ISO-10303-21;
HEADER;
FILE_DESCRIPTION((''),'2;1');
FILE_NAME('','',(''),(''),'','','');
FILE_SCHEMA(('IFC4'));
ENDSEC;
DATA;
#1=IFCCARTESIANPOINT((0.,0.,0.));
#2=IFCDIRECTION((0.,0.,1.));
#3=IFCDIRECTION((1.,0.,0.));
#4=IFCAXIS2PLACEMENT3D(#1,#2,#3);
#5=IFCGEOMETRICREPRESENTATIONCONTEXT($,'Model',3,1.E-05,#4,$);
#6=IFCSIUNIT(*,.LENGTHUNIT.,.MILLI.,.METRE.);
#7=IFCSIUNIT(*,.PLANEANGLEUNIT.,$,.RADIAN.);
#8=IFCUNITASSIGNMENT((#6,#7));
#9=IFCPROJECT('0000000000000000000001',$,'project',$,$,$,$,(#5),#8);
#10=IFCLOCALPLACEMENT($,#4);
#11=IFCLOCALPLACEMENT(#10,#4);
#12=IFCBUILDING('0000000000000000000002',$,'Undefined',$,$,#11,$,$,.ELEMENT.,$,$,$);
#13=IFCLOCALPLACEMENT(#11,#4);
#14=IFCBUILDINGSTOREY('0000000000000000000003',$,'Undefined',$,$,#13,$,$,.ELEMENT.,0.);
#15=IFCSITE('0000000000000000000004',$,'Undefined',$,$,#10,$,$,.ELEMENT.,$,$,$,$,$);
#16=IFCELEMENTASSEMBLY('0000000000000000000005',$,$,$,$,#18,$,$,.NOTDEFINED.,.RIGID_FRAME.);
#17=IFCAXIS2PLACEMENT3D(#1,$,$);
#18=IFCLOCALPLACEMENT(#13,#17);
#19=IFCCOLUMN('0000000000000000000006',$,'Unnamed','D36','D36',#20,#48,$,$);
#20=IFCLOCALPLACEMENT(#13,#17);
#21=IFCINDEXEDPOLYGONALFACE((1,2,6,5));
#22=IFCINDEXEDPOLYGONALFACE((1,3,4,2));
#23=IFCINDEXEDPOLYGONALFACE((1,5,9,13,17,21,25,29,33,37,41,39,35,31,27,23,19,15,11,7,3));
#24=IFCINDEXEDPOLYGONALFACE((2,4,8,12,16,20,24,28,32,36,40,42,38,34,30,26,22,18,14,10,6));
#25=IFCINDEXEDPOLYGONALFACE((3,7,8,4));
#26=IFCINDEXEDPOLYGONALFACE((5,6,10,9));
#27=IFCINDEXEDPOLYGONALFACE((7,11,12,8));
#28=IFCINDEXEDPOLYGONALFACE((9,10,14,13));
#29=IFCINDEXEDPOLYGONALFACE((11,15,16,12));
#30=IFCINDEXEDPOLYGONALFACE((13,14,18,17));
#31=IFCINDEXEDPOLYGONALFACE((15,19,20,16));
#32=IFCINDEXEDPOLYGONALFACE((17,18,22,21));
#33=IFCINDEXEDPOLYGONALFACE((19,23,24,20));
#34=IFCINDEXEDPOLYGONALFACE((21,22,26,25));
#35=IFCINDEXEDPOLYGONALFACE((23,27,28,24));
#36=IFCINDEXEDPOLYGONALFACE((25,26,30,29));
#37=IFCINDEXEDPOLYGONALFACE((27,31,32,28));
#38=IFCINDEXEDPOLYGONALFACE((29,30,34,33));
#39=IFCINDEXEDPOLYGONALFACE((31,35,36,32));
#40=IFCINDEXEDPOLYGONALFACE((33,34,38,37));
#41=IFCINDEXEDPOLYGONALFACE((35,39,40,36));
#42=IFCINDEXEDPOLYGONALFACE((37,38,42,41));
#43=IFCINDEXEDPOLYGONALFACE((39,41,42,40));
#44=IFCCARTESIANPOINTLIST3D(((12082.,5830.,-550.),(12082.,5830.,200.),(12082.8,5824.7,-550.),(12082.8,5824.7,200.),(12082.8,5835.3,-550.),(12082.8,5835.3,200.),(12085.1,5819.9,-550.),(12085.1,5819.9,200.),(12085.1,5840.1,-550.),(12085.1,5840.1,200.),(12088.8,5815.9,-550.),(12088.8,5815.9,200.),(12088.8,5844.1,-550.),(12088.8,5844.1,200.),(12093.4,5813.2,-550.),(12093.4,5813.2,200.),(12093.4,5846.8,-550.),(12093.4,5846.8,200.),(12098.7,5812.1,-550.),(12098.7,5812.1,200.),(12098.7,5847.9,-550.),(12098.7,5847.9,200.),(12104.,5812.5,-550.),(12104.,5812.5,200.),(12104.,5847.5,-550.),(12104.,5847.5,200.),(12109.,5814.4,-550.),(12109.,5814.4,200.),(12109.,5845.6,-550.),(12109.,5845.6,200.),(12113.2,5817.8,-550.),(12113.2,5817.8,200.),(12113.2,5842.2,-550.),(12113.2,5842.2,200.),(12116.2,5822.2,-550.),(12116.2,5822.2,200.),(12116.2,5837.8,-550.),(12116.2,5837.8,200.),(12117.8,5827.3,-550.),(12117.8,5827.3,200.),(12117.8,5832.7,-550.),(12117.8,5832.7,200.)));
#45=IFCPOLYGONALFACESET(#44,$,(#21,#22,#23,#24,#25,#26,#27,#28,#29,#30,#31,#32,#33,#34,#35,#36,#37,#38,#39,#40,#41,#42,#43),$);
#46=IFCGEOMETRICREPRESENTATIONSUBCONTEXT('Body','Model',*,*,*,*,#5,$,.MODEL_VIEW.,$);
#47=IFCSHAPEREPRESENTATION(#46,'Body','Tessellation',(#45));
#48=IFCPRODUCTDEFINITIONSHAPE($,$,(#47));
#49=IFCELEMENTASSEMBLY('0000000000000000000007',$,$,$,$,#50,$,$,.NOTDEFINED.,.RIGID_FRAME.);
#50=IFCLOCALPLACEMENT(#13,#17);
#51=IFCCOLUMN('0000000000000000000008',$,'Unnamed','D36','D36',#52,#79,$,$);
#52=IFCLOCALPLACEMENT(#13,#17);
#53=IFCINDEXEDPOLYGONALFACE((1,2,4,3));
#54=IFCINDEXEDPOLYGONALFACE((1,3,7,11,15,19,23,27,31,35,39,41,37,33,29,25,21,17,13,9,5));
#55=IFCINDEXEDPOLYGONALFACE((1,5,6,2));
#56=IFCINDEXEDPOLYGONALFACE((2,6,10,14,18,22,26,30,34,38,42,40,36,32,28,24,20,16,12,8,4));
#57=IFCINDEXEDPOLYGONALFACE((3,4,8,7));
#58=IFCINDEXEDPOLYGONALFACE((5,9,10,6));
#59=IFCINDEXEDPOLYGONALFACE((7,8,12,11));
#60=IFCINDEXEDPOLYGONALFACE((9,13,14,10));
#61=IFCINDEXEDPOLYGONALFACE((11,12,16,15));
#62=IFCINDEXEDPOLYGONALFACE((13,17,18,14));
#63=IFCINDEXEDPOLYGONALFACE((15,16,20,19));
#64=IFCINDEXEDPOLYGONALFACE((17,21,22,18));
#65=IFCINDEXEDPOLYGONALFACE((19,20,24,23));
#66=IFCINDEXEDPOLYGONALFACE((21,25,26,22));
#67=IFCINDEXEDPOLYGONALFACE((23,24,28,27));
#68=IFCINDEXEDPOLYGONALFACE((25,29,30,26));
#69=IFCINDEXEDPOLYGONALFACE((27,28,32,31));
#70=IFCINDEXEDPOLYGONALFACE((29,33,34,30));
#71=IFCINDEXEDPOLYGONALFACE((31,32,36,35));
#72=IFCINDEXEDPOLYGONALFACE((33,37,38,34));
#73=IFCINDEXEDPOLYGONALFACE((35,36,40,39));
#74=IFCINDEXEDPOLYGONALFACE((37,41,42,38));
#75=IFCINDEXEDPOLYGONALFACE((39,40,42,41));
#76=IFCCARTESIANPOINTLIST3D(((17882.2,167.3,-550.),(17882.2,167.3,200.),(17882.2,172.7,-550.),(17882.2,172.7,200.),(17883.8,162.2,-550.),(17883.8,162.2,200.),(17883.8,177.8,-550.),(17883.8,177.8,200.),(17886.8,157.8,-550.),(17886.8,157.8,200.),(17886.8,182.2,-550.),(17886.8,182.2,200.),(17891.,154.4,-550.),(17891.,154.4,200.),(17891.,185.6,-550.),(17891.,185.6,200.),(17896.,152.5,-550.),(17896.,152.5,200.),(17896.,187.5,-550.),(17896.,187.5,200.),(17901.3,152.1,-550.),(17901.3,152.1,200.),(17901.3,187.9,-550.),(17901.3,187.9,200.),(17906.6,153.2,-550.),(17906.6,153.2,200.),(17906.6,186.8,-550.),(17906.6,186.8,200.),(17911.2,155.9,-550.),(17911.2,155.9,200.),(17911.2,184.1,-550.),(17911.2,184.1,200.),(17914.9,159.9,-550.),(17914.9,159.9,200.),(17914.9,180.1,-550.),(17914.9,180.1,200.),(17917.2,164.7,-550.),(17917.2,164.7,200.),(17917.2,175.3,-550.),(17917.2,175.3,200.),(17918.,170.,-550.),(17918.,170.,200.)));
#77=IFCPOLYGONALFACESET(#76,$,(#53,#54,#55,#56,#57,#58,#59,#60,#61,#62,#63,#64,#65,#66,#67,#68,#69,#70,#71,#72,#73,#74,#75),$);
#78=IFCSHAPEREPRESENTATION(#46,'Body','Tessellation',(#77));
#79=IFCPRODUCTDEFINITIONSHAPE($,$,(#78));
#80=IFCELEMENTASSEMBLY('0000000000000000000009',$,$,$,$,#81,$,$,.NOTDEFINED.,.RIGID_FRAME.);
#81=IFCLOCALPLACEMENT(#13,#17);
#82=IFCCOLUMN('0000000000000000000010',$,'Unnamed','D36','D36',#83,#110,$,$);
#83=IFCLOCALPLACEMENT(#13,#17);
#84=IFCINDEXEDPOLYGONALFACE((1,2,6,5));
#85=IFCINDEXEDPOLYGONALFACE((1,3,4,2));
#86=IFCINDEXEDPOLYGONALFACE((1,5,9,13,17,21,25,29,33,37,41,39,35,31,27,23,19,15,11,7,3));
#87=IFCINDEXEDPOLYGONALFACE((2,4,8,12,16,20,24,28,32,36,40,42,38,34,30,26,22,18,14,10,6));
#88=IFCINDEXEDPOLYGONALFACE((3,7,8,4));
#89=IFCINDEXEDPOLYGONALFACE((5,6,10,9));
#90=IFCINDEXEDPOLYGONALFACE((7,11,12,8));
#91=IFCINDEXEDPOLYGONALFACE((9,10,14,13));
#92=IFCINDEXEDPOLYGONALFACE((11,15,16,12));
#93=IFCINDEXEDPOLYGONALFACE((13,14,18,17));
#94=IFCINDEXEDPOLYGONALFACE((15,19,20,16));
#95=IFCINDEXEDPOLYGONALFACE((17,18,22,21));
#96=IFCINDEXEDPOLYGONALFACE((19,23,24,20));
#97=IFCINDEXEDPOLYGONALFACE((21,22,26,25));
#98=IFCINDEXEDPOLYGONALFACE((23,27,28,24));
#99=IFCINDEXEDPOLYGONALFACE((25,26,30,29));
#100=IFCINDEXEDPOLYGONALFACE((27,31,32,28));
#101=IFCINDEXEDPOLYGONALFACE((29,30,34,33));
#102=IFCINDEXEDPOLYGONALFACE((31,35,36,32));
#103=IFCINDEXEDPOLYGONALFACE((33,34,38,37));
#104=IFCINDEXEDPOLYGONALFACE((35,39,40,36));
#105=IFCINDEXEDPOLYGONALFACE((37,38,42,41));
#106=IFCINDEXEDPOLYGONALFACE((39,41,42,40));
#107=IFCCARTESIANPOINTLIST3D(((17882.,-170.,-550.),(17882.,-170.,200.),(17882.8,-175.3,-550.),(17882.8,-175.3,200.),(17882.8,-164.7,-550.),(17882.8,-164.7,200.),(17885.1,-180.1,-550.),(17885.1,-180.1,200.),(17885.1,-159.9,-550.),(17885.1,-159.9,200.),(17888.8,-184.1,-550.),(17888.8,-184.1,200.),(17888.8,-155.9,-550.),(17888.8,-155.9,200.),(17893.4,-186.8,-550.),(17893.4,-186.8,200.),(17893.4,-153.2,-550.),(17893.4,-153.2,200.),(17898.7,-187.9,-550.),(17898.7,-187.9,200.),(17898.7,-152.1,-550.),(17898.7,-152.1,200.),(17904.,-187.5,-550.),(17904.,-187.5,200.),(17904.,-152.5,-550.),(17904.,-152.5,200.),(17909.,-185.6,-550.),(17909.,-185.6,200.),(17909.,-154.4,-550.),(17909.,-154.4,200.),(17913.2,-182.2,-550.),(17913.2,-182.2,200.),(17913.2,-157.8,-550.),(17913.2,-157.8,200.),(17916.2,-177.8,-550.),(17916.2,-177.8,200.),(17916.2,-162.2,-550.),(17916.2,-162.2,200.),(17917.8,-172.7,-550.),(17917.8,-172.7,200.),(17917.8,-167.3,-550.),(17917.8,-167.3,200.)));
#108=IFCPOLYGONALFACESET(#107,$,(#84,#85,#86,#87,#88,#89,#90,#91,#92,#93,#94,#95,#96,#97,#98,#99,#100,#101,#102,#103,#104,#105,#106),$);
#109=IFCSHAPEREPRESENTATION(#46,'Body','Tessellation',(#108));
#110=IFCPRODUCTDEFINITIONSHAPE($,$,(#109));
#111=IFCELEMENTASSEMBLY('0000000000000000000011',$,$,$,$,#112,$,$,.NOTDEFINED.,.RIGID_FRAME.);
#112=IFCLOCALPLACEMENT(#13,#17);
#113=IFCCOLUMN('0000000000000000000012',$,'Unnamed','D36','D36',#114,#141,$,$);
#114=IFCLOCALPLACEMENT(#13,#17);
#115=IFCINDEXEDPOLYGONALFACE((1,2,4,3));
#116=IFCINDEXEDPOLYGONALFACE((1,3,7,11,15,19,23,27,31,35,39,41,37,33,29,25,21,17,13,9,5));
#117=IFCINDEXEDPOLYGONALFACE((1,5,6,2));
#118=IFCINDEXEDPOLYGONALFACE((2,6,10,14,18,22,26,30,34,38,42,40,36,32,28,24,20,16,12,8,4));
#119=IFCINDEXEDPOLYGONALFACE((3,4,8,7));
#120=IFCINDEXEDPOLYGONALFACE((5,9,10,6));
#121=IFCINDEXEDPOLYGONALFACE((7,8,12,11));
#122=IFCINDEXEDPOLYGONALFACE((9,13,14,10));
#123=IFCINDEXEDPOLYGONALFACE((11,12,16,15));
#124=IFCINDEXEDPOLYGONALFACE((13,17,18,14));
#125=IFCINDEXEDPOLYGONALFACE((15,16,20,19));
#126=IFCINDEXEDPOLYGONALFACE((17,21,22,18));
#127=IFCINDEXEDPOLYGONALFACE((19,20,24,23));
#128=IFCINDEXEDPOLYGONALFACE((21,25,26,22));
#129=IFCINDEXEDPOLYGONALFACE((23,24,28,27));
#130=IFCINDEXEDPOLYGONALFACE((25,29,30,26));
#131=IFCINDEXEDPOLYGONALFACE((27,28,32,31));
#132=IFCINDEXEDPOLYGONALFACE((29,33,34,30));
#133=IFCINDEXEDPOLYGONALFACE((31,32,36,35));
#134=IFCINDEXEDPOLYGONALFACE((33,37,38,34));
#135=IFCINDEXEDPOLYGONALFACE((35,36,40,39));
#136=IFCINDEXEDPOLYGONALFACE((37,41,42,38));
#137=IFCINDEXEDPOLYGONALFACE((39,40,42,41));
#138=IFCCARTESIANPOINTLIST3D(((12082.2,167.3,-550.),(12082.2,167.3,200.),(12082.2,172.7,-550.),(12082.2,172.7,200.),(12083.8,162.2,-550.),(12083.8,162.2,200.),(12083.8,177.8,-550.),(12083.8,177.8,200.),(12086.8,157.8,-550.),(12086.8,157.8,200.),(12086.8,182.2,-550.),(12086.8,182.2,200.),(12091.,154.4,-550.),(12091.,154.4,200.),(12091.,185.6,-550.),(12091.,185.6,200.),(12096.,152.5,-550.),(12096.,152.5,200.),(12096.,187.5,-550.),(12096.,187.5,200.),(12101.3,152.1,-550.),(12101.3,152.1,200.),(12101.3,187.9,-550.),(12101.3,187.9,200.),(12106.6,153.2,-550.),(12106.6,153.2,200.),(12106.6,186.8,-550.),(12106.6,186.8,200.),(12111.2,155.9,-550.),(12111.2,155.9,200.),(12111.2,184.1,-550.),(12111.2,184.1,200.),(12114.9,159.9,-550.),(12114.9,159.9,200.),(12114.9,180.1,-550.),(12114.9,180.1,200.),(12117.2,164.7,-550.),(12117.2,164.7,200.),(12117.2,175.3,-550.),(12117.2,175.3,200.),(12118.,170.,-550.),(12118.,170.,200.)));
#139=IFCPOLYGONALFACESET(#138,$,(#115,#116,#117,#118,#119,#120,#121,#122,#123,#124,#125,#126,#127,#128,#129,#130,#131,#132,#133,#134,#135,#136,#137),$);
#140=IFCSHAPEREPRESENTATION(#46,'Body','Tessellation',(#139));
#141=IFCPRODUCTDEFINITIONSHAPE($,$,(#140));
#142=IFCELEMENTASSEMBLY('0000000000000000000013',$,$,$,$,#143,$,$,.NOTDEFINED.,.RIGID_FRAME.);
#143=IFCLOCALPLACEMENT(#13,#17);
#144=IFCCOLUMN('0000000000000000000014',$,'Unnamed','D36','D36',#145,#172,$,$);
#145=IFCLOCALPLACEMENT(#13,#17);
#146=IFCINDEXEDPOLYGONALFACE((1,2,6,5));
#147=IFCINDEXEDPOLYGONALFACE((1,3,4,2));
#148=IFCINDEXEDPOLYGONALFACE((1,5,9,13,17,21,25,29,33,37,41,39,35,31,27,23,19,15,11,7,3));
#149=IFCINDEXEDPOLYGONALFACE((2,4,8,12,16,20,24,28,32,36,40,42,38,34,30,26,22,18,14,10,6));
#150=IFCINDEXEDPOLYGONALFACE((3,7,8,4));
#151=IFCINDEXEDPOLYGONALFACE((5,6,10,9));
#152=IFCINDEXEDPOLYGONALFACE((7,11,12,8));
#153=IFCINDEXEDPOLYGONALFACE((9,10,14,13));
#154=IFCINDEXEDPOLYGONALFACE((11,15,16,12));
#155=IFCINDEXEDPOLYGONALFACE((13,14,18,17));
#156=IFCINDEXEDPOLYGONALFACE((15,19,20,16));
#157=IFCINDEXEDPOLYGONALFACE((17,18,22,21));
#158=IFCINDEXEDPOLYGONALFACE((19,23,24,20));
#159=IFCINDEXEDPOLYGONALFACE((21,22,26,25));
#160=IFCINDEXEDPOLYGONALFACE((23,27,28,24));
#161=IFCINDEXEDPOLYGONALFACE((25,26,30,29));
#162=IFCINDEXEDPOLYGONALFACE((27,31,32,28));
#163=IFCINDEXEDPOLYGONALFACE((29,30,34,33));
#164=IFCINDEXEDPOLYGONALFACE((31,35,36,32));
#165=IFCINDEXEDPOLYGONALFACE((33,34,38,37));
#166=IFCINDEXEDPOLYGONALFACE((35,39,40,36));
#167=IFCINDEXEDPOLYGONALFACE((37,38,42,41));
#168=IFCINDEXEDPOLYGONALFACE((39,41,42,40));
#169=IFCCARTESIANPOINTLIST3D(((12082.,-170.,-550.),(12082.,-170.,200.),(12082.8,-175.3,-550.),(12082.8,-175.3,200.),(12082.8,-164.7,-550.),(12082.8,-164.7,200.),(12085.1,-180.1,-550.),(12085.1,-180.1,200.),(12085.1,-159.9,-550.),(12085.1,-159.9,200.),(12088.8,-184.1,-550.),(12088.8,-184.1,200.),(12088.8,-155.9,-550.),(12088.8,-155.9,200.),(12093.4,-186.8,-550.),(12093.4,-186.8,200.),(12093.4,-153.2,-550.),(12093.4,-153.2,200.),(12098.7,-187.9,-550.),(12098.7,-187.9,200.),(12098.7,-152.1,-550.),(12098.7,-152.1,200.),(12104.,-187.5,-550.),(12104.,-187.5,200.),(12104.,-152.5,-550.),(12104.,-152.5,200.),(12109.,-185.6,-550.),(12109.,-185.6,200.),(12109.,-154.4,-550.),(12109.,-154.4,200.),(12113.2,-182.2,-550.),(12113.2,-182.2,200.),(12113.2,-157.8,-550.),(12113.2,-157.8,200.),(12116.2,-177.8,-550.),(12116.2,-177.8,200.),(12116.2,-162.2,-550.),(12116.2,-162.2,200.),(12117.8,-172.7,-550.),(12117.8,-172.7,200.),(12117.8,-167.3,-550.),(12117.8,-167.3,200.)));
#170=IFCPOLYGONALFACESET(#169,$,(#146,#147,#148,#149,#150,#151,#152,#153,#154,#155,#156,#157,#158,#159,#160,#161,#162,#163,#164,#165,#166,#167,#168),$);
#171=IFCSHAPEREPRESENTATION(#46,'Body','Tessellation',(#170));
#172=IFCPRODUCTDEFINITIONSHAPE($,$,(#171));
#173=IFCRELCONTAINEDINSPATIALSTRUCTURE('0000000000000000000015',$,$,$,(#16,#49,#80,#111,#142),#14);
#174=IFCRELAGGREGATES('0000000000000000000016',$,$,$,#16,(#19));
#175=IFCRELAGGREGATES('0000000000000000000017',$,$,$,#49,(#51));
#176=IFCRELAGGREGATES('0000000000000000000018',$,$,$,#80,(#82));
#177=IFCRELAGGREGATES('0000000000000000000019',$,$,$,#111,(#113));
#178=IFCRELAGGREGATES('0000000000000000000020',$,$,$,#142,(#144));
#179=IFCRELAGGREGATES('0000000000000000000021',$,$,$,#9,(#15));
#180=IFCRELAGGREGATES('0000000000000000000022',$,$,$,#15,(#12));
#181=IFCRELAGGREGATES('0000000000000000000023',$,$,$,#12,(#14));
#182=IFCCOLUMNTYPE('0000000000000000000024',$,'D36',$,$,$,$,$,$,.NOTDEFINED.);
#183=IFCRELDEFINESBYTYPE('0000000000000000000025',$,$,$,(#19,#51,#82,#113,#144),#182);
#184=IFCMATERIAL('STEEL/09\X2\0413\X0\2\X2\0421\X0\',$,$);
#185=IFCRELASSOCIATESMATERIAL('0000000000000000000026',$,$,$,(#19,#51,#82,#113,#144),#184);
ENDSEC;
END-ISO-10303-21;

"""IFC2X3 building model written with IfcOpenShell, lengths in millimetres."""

from ifc_helpers import new_model, si_unit, frame, origin_with_axes, origin_2d_with_axis, place, context, subcontext, project, spatial, circle, extrude, material, type_object, element, aggregate, save


model = new_model("IFC2X3")

# Units and contexts
model_context = context("Model", 3, precision=1e-05, world=origin_with_axes())
body_context = subcontext(model_context, "Body", "Model", "MODEL_VIEW")
ifc_project = project(units=[si_unit("LENGTHUNIT", "METRE", prefix="MILLI"), si_unit("PLANEANGLEUNIT", "RADIAN")], contexts=[model_context])

# Site, building, storey
site_placement = place(None, origin_with_axes())
site = spatial("IfcSite", under=ifc_project, at=site_placement, Name="Undefined", CompositionType="ELEMENT")
building_placement = place(site_placement, origin_with_axes())
building = spatial("IfcBuilding", under=site, at=building_placement, Name="Undefined", CompositionType="ELEMENT")
storey_placement = place(building_placement, origin_with_axes())
storey = spatial("IfcBuildingStorey", under=building, at=storey_placement, Name="Undefined", CompositionType="ELEMENT", Elevation=0.0)

# Element assemblies, columns
ifc_material_1 = material(Name="STEEL/09Г2С")
column_type_1 = type_object("IfcColumnType", Name="D36", PredefinedType="NOTDEFINED")
assembly_1_placement = place(storey_placement, origin_with_axes())
assembly_1 = element("IfcElementAssembly", 1, at=assembly_1_placement, inside=storey, AssemblyPlace="NOTDEFINED", PredefinedType="RIGID_FRAME")
column_1_placement = place(assembly_1_placement, frame((12100.0, 5830.0, -550.0), z_axis=(0.0, 0.0, 1.0), x_axis=(0.0, 1.0, 0.0)))
column_1 = element("IfcColumn", 2, at=column_1_placement, type_object=column_type_1, material=ifc_material_1, Name="Unnamed", Description="D36", ObjectType="D36", context=body_context, shape_type="SweptSolid", body=[
    extrude(circle(Radius=18.0, at=origin_2d_with_axis()), frame((0.0, 0.0, 750.0), z_axis=(0.0, 0.0, -1.0), x_axis=(0.0, 1.0, 0.0)), (0.0, 0.0, 1.0), 750.0),
])
aggregate(assembly_1, [column_1])
assembly_2_placement = place(storey_placement, origin_with_axes())
assembly_2 = element("IfcElementAssembly", 3, at=assembly_2_placement, inside=storey, AssemblyPlace="NOTDEFINED", PredefinedType="RIGID_FRAME")
column_2_placement = place(assembly_2_placement, frame((17900.0, 170.0, -550.0), z_axis=(0.0, 0.0, 1.0), x_axis=(0.0, -1.0, 0.0)))
column_2 = element("IfcColumn", 4, at=column_2_placement, type_object=column_type_1, material=ifc_material_1, Name="Unnamed", Description="D36", ObjectType="D36", context=body_context, shape_type="SweptSolid", body=[
    extrude(circle(Radius=18.0, at=origin_2d_with_axis()), frame((0.0, 0.0, 750.0), z_axis=(0.0, 0.0, -1.0), x_axis=(0.0, 1.0, 0.0)), (0.0, 0.0, 1.0), 750.0),
])
aggregate(assembly_2, [column_2])
assembly_3_placement = place(storey_placement, origin_with_axes())
assembly_3 = element("IfcElementAssembly", 5, at=assembly_3_placement, inside=storey, AssemblyPlace="NOTDEFINED", PredefinedType="RIGID_FRAME")
column_3_placement = place(assembly_3_placement, frame((17900.0, -170.0, -550.0), z_axis=(0.0, 0.0, 1.0), x_axis=(0.0, 1.0, 0.0)))
column_3 = element("IfcColumn", 6, at=column_3_placement, type_object=column_type_1, material=ifc_material_1, Name="Unnamed", Description="D36", ObjectType="D36", context=body_context, shape_type="SweptSolid", body=[
    extrude(circle(Radius=18.0, at=origin_2d_with_axis()), frame((0.0, 0.0, 750.0), z_axis=(0.0, 0.0, -1.0), x_axis=(0.0, 1.0, 0.0)), (0.0, 0.0, 1.0), 750.0),
])
aggregate(assembly_3, [column_3])
assembly_4_placement = place(storey_placement, origin_with_axes())
assembly_4 = element("IfcElementAssembly", 7, at=assembly_4_placement, inside=storey, AssemblyPlace="NOTDEFINED", PredefinedType="RIGID_FRAME")
column_4_placement = place(assembly_4_placement, frame((12100.0, 170.0, -550.0), z_axis=(0.0, 0.0, 1.0), x_axis=(0.0, -1.0, 0.0)))
column_4 = element("IfcColumn", 8, at=column_4_placement, type_object=column_type_1, material=ifc_material_1, Name="Unnamed", Description="D36", ObjectType="D36", context=body_context, shape_type="SweptSolid", body=[
    extrude(circle(Radius=18.0, at=origin_2d_with_axis()), frame((0.0, 0.0, 750.0), z_axis=(0.0, 0.0, -1.0), x_axis=(0.0, 1.0, 0.0)), (0.0, 0.0, 1.0), 750.0),
])
aggregate(assembly_4, [column_4])
assembly_5_placement = place(storey_placement, origin_with_axes())
assembly_5 = element("IfcElementAssembly", 9, at=assembly_5_placement, inside=storey, AssemblyPlace="NOTDEFINED", PredefinedType="RIGID_FRAME")
column_5_placement = place(assembly_5_placement, frame((12100.0, -170.0, -550.0), z_axis=(0.0, 0.0, 1.0), x_axis=(0.0, 1.0, 0.0)))
column_5 = element("IfcColumn", 10, at=column_5_placement, type_object=column_type_1, material=ifc_material_1, Name="Unnamed", Description="D36", ObjectType="D36", context=body_context, shape_type="SweptSolid", body=[
    extrude(circle(Radius=18.0, at=origin_2d_with_axis()), frame((0.0, 0.0, 750.0), z_axis=(0.0, 0.0, -1.0), x_axis=(0.0, 1.0, 0.0)), (0.0, 0.0, 1.0), 750.0),
])
aggregate(assembly_5, [column_5])

save(model, "model.ifc")
